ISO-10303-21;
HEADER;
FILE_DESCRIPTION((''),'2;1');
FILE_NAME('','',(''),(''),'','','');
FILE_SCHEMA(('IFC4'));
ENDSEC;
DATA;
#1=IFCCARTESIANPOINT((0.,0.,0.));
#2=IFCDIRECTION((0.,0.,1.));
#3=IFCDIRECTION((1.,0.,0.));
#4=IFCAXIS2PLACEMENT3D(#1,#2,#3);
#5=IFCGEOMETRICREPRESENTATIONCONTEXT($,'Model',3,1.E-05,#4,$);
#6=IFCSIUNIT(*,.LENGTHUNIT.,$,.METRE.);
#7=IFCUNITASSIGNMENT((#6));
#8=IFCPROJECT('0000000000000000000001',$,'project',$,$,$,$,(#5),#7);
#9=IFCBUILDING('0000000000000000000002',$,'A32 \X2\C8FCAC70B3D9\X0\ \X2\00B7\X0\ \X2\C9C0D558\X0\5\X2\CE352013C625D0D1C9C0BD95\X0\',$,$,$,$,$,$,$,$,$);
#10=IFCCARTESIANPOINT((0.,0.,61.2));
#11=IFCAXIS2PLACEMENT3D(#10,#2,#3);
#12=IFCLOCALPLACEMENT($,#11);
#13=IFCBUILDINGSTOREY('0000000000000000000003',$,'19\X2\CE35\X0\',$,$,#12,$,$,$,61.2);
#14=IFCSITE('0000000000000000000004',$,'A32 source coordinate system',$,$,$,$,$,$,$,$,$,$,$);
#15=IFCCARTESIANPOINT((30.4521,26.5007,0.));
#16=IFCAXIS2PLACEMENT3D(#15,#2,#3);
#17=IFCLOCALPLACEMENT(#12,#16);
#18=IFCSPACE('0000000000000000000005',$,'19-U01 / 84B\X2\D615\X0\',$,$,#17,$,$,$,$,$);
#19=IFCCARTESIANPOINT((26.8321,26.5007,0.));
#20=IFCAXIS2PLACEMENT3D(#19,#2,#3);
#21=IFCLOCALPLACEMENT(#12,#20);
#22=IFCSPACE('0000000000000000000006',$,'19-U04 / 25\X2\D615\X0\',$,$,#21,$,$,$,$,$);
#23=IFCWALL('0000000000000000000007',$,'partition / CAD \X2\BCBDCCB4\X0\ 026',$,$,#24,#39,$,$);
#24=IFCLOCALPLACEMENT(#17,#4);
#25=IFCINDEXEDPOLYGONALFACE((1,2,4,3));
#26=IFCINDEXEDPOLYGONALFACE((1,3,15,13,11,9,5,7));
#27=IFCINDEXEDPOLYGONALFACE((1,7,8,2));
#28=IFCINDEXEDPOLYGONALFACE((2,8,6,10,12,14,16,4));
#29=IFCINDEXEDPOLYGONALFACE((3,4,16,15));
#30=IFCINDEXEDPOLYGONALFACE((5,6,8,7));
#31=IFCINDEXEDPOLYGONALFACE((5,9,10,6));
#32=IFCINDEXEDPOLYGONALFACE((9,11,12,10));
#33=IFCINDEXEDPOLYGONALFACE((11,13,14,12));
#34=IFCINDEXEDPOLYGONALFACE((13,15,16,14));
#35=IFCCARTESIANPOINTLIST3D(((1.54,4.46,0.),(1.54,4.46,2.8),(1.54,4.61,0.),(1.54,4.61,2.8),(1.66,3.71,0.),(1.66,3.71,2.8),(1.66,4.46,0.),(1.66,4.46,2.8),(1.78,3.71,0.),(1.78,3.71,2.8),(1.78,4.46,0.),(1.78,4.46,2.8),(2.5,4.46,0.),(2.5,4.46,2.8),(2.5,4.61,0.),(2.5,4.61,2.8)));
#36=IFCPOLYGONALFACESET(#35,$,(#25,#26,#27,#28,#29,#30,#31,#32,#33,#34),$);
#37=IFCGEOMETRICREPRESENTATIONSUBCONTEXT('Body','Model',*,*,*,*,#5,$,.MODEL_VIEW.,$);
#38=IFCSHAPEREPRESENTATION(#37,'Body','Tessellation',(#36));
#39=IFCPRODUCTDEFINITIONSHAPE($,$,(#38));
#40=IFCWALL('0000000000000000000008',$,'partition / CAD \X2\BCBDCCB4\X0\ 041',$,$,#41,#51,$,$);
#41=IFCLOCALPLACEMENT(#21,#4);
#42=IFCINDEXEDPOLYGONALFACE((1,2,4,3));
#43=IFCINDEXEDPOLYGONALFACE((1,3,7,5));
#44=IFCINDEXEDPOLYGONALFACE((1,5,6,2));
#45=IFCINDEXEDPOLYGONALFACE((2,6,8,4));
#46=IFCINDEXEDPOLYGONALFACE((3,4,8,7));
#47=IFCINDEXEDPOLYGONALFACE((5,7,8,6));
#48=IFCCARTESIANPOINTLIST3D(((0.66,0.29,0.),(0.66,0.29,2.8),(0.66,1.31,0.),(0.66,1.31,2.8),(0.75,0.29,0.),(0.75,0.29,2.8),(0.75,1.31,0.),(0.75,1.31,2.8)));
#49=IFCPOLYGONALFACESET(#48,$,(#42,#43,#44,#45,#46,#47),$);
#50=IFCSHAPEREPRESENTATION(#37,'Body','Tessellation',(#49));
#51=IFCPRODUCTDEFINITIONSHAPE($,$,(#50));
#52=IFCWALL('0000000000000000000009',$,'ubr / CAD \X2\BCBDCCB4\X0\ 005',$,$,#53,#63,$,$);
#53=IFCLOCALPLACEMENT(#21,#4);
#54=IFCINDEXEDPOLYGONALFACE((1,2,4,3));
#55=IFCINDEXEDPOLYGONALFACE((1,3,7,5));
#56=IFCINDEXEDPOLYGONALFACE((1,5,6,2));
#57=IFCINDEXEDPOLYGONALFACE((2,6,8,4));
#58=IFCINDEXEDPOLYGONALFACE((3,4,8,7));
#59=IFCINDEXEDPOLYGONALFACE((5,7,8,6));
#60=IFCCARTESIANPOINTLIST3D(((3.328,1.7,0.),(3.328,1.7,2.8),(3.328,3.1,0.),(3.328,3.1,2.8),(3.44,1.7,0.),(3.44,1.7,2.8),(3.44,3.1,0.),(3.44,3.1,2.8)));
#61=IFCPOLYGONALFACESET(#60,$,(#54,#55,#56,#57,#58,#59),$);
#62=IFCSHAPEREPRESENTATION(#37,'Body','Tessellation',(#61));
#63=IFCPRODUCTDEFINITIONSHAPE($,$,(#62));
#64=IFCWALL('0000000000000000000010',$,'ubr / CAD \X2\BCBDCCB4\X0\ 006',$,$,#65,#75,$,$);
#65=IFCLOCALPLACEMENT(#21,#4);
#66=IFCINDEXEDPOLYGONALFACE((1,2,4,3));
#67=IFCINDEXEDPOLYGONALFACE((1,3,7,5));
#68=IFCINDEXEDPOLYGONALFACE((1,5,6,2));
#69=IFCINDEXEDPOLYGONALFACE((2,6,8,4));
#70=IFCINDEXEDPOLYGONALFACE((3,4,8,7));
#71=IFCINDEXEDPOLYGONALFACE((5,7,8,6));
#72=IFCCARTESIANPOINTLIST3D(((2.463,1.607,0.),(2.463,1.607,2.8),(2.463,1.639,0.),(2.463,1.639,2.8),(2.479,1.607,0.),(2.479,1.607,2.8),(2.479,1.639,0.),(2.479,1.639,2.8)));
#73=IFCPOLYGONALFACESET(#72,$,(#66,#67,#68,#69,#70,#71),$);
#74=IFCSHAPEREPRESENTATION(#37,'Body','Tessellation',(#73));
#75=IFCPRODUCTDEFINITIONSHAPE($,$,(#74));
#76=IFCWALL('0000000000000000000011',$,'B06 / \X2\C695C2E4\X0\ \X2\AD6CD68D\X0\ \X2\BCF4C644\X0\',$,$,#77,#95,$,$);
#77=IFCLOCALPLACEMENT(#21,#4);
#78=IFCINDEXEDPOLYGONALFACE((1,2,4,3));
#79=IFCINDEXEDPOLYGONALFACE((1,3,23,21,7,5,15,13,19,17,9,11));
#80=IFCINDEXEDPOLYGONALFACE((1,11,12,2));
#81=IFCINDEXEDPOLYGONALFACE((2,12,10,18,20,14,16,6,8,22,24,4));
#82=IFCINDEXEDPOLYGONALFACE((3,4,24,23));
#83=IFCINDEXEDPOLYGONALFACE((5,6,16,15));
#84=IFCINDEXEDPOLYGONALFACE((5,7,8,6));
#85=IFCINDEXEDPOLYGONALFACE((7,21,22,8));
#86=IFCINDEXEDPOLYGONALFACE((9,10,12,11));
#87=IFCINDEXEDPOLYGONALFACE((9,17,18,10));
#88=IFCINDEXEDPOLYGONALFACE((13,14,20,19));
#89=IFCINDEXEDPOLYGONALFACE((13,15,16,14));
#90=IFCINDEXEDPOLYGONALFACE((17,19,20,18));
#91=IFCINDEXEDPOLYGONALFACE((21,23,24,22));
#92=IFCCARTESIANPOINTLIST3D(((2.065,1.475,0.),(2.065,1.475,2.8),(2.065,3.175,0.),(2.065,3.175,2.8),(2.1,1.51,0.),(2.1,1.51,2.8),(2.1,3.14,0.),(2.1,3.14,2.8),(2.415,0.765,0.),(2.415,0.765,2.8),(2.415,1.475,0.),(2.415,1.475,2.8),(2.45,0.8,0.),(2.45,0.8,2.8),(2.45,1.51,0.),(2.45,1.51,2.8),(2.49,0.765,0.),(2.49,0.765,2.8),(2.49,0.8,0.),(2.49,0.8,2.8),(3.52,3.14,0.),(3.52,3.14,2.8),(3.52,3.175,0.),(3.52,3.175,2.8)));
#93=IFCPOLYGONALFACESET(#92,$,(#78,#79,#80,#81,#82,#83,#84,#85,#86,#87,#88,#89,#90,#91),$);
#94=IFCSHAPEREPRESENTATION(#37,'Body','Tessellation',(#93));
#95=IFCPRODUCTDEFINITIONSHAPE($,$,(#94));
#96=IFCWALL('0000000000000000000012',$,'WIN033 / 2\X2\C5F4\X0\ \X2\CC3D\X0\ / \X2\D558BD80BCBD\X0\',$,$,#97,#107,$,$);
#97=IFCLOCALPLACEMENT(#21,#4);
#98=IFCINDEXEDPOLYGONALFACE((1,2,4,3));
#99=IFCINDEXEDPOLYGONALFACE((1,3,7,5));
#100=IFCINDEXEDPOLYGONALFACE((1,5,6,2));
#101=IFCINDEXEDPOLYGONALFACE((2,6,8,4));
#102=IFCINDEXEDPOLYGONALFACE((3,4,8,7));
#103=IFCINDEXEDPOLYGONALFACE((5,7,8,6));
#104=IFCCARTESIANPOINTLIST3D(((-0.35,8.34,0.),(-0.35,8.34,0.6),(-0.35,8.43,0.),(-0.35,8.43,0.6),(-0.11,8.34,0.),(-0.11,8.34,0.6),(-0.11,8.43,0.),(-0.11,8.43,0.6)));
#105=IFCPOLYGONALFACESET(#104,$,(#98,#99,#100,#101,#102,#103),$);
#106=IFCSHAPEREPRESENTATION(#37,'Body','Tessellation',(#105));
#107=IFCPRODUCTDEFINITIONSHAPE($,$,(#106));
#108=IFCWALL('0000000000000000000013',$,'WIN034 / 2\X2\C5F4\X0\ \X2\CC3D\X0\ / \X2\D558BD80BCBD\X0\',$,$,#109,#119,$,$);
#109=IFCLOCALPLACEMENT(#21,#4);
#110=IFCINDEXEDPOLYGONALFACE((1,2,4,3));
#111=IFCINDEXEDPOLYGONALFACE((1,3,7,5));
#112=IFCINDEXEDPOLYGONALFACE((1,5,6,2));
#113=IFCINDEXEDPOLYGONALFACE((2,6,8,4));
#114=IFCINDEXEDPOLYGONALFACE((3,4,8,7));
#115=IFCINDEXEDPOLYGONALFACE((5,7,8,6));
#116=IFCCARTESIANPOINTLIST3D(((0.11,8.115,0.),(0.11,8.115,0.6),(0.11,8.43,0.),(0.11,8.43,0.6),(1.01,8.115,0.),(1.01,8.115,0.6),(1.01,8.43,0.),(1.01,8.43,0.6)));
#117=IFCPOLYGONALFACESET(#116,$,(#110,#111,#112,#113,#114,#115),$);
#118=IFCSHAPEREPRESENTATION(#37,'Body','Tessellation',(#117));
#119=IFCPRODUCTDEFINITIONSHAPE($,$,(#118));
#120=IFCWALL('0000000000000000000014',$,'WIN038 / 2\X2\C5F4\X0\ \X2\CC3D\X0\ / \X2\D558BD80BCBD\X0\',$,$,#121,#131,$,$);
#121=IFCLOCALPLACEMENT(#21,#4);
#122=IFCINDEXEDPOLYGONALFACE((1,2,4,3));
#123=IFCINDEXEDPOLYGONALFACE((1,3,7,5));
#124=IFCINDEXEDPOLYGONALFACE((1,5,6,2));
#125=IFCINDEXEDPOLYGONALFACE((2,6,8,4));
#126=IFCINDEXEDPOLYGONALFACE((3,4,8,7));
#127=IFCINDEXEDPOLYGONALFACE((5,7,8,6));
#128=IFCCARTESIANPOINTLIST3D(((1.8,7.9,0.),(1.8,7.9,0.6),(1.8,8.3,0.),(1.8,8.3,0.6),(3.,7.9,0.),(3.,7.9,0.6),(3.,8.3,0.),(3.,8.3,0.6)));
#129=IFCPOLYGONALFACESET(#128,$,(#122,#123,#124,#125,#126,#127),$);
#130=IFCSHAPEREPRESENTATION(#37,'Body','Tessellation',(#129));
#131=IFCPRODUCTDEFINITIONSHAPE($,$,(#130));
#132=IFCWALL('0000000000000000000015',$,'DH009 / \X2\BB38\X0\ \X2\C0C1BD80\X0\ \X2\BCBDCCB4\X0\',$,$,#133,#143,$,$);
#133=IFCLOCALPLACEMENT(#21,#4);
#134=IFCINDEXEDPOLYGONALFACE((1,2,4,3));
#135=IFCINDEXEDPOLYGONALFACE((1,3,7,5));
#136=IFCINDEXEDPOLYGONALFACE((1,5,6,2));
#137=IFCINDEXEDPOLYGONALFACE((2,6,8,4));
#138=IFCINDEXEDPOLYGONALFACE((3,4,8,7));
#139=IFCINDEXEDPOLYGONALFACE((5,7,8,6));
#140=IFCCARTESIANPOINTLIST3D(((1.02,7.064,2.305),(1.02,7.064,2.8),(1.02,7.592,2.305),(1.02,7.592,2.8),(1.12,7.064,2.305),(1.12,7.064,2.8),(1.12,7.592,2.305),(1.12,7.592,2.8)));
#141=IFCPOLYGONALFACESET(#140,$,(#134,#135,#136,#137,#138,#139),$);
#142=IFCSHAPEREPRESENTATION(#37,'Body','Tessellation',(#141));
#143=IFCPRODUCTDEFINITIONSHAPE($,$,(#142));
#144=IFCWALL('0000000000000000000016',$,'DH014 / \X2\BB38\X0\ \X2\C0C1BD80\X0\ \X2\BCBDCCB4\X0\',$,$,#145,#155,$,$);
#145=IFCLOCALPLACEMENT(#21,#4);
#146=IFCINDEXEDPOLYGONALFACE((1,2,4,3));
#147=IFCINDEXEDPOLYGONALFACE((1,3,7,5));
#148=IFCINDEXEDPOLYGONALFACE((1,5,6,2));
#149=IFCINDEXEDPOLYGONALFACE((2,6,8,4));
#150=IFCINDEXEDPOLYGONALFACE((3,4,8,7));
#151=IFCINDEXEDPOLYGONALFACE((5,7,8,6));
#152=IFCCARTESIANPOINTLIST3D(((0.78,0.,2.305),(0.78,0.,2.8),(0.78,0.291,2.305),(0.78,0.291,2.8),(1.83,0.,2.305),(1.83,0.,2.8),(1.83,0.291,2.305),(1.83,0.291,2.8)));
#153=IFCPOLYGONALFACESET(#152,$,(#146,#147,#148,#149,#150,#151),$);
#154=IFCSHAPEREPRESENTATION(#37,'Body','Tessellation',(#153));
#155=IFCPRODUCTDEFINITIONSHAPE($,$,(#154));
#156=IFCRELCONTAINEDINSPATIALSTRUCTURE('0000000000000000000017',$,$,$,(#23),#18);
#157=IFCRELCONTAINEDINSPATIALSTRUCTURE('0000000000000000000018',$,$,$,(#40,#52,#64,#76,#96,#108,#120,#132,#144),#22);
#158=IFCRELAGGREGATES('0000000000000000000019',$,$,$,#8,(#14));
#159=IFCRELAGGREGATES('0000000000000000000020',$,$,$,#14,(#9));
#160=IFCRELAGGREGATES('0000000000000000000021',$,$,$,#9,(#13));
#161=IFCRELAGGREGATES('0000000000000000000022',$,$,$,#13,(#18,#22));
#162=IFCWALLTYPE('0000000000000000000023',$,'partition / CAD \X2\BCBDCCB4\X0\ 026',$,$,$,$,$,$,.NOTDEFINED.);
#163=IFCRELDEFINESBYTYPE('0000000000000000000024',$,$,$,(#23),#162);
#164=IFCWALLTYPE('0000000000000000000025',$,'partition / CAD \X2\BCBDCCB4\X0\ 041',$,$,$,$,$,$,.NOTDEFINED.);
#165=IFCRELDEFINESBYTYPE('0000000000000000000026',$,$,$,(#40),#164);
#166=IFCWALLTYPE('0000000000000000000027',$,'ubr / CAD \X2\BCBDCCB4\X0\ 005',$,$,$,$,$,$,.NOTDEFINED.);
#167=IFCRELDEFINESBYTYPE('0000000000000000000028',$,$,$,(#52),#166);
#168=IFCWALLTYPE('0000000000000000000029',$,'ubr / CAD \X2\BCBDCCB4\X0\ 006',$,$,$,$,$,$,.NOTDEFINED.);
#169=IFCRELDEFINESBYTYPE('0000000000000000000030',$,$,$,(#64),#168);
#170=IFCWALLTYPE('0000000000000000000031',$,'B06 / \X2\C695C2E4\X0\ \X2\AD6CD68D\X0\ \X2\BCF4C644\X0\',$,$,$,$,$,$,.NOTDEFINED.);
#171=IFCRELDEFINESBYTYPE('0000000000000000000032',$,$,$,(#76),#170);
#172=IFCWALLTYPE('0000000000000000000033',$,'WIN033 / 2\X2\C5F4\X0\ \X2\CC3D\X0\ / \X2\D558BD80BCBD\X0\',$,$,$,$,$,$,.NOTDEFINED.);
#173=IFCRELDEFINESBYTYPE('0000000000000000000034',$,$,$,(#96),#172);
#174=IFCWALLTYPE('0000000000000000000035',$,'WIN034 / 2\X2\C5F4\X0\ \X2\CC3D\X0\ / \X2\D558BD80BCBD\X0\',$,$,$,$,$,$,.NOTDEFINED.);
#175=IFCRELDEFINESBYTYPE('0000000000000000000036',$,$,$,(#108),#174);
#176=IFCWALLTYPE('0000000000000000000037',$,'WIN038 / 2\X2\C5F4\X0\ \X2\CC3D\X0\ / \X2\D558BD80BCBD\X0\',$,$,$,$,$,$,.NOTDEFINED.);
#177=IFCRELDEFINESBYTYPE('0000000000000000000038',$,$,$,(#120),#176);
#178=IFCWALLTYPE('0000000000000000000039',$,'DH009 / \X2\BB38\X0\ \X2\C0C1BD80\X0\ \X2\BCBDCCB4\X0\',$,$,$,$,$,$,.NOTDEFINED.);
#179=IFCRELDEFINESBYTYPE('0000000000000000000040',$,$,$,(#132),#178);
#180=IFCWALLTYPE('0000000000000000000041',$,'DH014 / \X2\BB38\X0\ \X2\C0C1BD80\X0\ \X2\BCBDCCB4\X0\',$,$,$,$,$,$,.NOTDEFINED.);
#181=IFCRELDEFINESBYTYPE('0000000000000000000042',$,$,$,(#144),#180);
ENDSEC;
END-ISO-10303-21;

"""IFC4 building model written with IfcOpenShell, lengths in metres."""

from ifc_helpers import new_model, si_unit, frame, origin, origin_with_axes, place, context, subcontext, project, spatial, polyline, outline, extrude, source, transform, mapped, type_object, type_shapes, element, save


model = new_model("IFC4")

# Units and contexts
model_context = context("Model", 3, precision=1e-05, world=origin_with_axes())
body_context = subcontext(model_context, "Body", "Model", "MODEL_VIEW")
ifc_project = project(units=[si_unit("LENGTHUNIT", "METRE")], contexts=[model_context])

# Site, building, storey, space
site = spatial("IfcSite", under=ifc_project, Name="A32 source coordinate system")
building = spatial("IfcBuilding", under=site, Name="A32 주거동 · 지하5층–옥탑지붕")
storey_placement = place(None, frame((0.0, 0.0, 61.2), z_axis=(0.0, 0.0, 1.0), x_axis=(1.0, 0.0, 0.0)))
storey = spatial("IfcBuildingStorey", under=building, at=storey_placement, Name="19층", Elevation=61.2)
space_1_placement = place(storey_placement, frame((30.4521, 26.5007, 0.0), z_axis=(0.0, 0.0, 1.0), x_axis=(1.0, 0.0, 0.0)))
space_1 = spatial("IfcSpace", under=storey, at=space_1_placement, Name="19-U01 / 84B형")

# Wall
wall_type_1 = type_object("IfcWallType", Name="partition / CAD 벽체 026", PredefinedType="NOTDEFINED")
shared_shape_1 = source(origin(), body_context, "Body", "SweptSolid", [
    extrude(outline(polyline([(1.54, 4.46), (1.54, 4.61), (2.5, 4.61), (2.5, 4.46), (1.78, 4.46), (1.78, 3.71), (1.66, 3.71), (1.66, 4.46), (1.54, 4.46)])), origin(), (0.0, 0.0, 1.0), 2.8),
])
type_shapes(wall_type_1, [shared_shape_1])
wall_1_placement = place(space_1_placement, origin_with_axes())
element("IfcWall", 1, at=wall_1_placement, inside=space_1, type_object=wall_type_1, Name="partition / CAD 벽체 026", context=body_context, shape_type="MappedRepresentation", body=[
    mapped(shared_shape_1, transform((0.0, 0.0, 0.0), scale=1.0)),
])

# Shared definitions
space_2_placement = place(storey_placement, frame((26.8321, 26.5007, 0.0), z_axis=(0.0, 0.0, 1.0), x_axis=(1.0, 0.0, 0.0)))
space_2 = spatial("IfcSpace", under=storey, at=space_2_placement, Name="19-U04 / 25형")

# Walls
wall_type_2 = type_object("IfcWallType", Name="partition / CAD 벽체 041", PredefinedType="NOTDEFINED")
shared_shape_2 = source(origin(), body_context, "Body", "SweptSolid", [
    extrude(outline(polyline([(0.75, 1.31), (0.75, 0.29), (0.66, 0.29), (0.66, 1.31), (0.75, 1.31)])), origin(), (0.0, 0.0, 1.0), 2.8),
])
type_shapes(wall_type_2, [shared_shape_2])
wall_2_placement = place(space_2_placement, origin_with_axes())
element("IfcWall", 2, at=wall_2_placement, inside=space_2, type_object=wall_type_2, Name="partition / CAD 벽체 041", context=body_context, shape_type="MappedRepresentation", body=[
    mapped(shared_shape_2, transform((0.0, 0.0, 0.0), scale=1.0)),
])
wall_type_3 = type_object("IfcWallType", Name="ubr / CAD 벽체 005", PredefinedType="NOTDEFINED")
shared_shape_3 = source(origin(), body_context, "Body", "SweptSolid", [
    extrude(outline(polyline([(3.44, 3.1), (3.44, 1.7), (3.328, 1.7), (3.328, 3.1), (3.44, 3.1)])), origin(), (0.0, 0.0, 1.0), 2.8),
])
type_shapes(wall_type_3, [shared_shape_3])
wall_3_placement = place(space_2_placement, origin_with_axes())
element("IfcWall", 3, at=wall_3_placement, inside=space_2, type_object=wall_type_3, Name="ubr / CAD 벽체 005", context=body_context, shape_type="MappedRepresentation", body=[
    mapped(shared_shape_3, transform((0.0, 0.0, 0.0), scale=1.0)),
])
wall_type_4 = type_object("IfcWallType", Name="ubr / CAD 벽체 006", PredefinedType="NOTDEFINED")
shared_shape_4 = source(origin(), body_context, "Body", "SweptSolid", [
    extrude(outline(polyline([(2.463, 1.639), (2.479, 1.639), (2.479, 1.607), (2.463, 1.607), (2.463, 1.639)])), origin(), (0.0, 0.0, 1.0), 2.8),
])
type_shapes(wall_type_4, [shared_shape_4])
wall_4_placement = place(space_2_placement, origin_with_axes())
element("IfcWall", 4, at=wall_4_placement, inside=space_2, type_object=wall_type_4, Name="ubr / CAD 벽체 006", context=body_context, shape_type="MappedRepresentation", body=[
    mapped(shared_shape_4, transform((0.0, 0.0, 0.0), scale=1.0)),
])
wall_type_5 = type_object("IfcWallType", Name="B06 / 욕실 구획 보완", PredefinedType="NOTDEFINED")
shared_shape_5 = source(origin(), body_context, "Body", "SweptSolid", [
    extrude(outline(polyline([(3.52, 3.14), (2.1, 3.14), (2.1, 1.51), (2.45, 1.51), (2.45, 0.8), (2.49, 0.8), (2.49, 0.765), (2.415, 0.765), (2.415, 1.475), (2.065, 1.475), (2.065, 3.175), (3.52, 3.175), (3.52, 3.14)])), origin(), (0.0, 0.0, 1.0), 2.8),
])
type_shapes(wall_type_5, [shared_shape_5])
wall_5_placement = place(space_2_placement, origin_with_axes())
element("IfcWall", 5, at=wall_5_placement, inside=space_2, type_object=wall_type_5, Name="B06 / 욕실 구획 보완", context=body_context, shape_type="MappedRepresentation", body=[
    mapped(shared_shape_5, transform((0.0, 0.0, 0.0), scale=1.0)),
])
wall_type_6 = type_object("IfcWallType", Name="WIN033 / 2열 창 / 하부벽", PredefinedType="NOTDEFINED")
shared_shape_6 = source(origin(), body_context, "Body", "SweptSolid", [
    extrude(outline(polyline([(-0.11, 8.43), (-0.11, 8.34), (-0.35, 8.34), (-0.35, 8.43), (-0.11, 8.43)])), origin(), (0.0, 0.0, 1.0), 0.6),
])
type_shapes(wall_type_6, [shared_shape_6])
wall_6_placement = place(space_2_placement, origin_with_axes())
element("IfcWall", 6, at=wall_6_placement, inside=space_2, type_object=wall_type_6, Name="WIN033 / 2열 창 / 하부벽", context=body_context, shape_type="MappedRepresentation", body=[
    mapped(shared_shape_6, transform((0.0, 0.0, 0.0), scale=1.0)),
])
wall_type_7 = type_object("IfcWallType", Name="WIN034 / 2열 창 / 하부벽", PredefinedType="NOTDEFINED")
shared_shape_7 = source(origin(), body_context, "Body", "SweptSolid", [
    extrude(outline(polyline([(0.11, 8.115), (0.11, 8.43), (1.01, 8.43), (1.01, 8.115), (0.11, 8.115)])), origin(), (0.0, 0.0, 1.0), 0.6),
])
type_shapes(wall_type_7, [shared_shape_7])
wall_7_placement = place(space_2_placement, origin_with_axes())
element("IfcWall", 7, at=wall_7_placement, inside=space_2, type_object=wall_type_7, Name="WIN034 / 2열 창 / 하부벽", context=body_context, shape_type="MappedRepresentation", body=[
    mapped(shared_shape_7, transform((0.0, 0.0, 0.0), scale=1.0)),
])
wall_type_8 = type_object("IfcWallType", Name="WIN038 / 2열 창 / 하부벽", PredefinedType="NOTDEFINED")
shared_shape_8 = source(origin(), body_context, "Body", "SweptSolid", [
    extrude(outline(polyline([(1.8, 7.9), (1.8, 8.3), (3.0, 8.3), (3.0, 7.9), (1.8, 7.9)])), origin(), (0.0, 0.0, 1.0), 0.6),
])
type_shapes(wall_type_8, [shared_shape_8])
wall_8_placement = place(space_2_placement, origin_with_axes())
element("IfcWall", 8, at=wall_8_placement, inside=space_2, type_object=wall_type_8, Name="WIN038 / 2열 창 / 하부벽", context=body_context, shape_type="MappedRepresentation", body=[
    mapped(shared_shape_8, transform((0.0, 0.0, 0.0), scale=1.0)),
])
wall_type_9 = type_object("IfcWallType", Name="DH009 / 문 상부 벽체", PredefinedType="NOTDEFINED")
shared_shape_9 = source(origin(), body_context, "Body", "SweptSolid", [
    extrude(outline(polyline([(1.02, 7.064), (1.02, 7.592), (1.12, 7.592), (1.12, 7.064), (1.02, 7.064)])), frame((0.0, 0.0, 2.305)), (0.0, 0.0, 1.0), 0.495),
])
type_shapes(wall_type_9, [shared_shape_9])
wall_9_placement = place(space_2_placement, origin_with_axes())
element("IfcWall", 9, at=wall_9_placement, inside=space_2, type_object=wall_type_9, Name="DH009 / 문 상부 벽체", context=body_context, shape_type="MappedRepresentation", body=[
    mapped(shared_shape_9, transform((0.0, 0.0, 0.0), scale=1.0)),
])
wall_type_10 = type_object("IfcWallType", Name="DH014 / 문 상부 벽체", PredefinedType="NOTDEFINED")
shared_shape_10 = source(origin(), body_context, "Body", "SweptSolid", [
    extrude(outline(polyline([(0.78, 0.291), (1.83, 0.291), (1.83, 0.0), (0.78, 0.0), (0.78, 0.291)])), frame((0.0, 0.0, 2.305)), (0.0, 0.0, 1.0), 0.495),
])
type_shapes(wall_type_10, [shared_shape_10])
wall_10_placement = place(space_2_placement, origin_with_axes())
element("IfcWall", 10, at=wall_10_placement, inside=space_2, type_object=wall_type_10, Name="DH014 / 문 상부 벽체", context=body_context, shape_type="MappedRepresentation", body=[
    mapped(shared_shape_10, transform((0.0, 0.0, 0.0), scale=1.0)),
])

save(model, "model.ifc")
